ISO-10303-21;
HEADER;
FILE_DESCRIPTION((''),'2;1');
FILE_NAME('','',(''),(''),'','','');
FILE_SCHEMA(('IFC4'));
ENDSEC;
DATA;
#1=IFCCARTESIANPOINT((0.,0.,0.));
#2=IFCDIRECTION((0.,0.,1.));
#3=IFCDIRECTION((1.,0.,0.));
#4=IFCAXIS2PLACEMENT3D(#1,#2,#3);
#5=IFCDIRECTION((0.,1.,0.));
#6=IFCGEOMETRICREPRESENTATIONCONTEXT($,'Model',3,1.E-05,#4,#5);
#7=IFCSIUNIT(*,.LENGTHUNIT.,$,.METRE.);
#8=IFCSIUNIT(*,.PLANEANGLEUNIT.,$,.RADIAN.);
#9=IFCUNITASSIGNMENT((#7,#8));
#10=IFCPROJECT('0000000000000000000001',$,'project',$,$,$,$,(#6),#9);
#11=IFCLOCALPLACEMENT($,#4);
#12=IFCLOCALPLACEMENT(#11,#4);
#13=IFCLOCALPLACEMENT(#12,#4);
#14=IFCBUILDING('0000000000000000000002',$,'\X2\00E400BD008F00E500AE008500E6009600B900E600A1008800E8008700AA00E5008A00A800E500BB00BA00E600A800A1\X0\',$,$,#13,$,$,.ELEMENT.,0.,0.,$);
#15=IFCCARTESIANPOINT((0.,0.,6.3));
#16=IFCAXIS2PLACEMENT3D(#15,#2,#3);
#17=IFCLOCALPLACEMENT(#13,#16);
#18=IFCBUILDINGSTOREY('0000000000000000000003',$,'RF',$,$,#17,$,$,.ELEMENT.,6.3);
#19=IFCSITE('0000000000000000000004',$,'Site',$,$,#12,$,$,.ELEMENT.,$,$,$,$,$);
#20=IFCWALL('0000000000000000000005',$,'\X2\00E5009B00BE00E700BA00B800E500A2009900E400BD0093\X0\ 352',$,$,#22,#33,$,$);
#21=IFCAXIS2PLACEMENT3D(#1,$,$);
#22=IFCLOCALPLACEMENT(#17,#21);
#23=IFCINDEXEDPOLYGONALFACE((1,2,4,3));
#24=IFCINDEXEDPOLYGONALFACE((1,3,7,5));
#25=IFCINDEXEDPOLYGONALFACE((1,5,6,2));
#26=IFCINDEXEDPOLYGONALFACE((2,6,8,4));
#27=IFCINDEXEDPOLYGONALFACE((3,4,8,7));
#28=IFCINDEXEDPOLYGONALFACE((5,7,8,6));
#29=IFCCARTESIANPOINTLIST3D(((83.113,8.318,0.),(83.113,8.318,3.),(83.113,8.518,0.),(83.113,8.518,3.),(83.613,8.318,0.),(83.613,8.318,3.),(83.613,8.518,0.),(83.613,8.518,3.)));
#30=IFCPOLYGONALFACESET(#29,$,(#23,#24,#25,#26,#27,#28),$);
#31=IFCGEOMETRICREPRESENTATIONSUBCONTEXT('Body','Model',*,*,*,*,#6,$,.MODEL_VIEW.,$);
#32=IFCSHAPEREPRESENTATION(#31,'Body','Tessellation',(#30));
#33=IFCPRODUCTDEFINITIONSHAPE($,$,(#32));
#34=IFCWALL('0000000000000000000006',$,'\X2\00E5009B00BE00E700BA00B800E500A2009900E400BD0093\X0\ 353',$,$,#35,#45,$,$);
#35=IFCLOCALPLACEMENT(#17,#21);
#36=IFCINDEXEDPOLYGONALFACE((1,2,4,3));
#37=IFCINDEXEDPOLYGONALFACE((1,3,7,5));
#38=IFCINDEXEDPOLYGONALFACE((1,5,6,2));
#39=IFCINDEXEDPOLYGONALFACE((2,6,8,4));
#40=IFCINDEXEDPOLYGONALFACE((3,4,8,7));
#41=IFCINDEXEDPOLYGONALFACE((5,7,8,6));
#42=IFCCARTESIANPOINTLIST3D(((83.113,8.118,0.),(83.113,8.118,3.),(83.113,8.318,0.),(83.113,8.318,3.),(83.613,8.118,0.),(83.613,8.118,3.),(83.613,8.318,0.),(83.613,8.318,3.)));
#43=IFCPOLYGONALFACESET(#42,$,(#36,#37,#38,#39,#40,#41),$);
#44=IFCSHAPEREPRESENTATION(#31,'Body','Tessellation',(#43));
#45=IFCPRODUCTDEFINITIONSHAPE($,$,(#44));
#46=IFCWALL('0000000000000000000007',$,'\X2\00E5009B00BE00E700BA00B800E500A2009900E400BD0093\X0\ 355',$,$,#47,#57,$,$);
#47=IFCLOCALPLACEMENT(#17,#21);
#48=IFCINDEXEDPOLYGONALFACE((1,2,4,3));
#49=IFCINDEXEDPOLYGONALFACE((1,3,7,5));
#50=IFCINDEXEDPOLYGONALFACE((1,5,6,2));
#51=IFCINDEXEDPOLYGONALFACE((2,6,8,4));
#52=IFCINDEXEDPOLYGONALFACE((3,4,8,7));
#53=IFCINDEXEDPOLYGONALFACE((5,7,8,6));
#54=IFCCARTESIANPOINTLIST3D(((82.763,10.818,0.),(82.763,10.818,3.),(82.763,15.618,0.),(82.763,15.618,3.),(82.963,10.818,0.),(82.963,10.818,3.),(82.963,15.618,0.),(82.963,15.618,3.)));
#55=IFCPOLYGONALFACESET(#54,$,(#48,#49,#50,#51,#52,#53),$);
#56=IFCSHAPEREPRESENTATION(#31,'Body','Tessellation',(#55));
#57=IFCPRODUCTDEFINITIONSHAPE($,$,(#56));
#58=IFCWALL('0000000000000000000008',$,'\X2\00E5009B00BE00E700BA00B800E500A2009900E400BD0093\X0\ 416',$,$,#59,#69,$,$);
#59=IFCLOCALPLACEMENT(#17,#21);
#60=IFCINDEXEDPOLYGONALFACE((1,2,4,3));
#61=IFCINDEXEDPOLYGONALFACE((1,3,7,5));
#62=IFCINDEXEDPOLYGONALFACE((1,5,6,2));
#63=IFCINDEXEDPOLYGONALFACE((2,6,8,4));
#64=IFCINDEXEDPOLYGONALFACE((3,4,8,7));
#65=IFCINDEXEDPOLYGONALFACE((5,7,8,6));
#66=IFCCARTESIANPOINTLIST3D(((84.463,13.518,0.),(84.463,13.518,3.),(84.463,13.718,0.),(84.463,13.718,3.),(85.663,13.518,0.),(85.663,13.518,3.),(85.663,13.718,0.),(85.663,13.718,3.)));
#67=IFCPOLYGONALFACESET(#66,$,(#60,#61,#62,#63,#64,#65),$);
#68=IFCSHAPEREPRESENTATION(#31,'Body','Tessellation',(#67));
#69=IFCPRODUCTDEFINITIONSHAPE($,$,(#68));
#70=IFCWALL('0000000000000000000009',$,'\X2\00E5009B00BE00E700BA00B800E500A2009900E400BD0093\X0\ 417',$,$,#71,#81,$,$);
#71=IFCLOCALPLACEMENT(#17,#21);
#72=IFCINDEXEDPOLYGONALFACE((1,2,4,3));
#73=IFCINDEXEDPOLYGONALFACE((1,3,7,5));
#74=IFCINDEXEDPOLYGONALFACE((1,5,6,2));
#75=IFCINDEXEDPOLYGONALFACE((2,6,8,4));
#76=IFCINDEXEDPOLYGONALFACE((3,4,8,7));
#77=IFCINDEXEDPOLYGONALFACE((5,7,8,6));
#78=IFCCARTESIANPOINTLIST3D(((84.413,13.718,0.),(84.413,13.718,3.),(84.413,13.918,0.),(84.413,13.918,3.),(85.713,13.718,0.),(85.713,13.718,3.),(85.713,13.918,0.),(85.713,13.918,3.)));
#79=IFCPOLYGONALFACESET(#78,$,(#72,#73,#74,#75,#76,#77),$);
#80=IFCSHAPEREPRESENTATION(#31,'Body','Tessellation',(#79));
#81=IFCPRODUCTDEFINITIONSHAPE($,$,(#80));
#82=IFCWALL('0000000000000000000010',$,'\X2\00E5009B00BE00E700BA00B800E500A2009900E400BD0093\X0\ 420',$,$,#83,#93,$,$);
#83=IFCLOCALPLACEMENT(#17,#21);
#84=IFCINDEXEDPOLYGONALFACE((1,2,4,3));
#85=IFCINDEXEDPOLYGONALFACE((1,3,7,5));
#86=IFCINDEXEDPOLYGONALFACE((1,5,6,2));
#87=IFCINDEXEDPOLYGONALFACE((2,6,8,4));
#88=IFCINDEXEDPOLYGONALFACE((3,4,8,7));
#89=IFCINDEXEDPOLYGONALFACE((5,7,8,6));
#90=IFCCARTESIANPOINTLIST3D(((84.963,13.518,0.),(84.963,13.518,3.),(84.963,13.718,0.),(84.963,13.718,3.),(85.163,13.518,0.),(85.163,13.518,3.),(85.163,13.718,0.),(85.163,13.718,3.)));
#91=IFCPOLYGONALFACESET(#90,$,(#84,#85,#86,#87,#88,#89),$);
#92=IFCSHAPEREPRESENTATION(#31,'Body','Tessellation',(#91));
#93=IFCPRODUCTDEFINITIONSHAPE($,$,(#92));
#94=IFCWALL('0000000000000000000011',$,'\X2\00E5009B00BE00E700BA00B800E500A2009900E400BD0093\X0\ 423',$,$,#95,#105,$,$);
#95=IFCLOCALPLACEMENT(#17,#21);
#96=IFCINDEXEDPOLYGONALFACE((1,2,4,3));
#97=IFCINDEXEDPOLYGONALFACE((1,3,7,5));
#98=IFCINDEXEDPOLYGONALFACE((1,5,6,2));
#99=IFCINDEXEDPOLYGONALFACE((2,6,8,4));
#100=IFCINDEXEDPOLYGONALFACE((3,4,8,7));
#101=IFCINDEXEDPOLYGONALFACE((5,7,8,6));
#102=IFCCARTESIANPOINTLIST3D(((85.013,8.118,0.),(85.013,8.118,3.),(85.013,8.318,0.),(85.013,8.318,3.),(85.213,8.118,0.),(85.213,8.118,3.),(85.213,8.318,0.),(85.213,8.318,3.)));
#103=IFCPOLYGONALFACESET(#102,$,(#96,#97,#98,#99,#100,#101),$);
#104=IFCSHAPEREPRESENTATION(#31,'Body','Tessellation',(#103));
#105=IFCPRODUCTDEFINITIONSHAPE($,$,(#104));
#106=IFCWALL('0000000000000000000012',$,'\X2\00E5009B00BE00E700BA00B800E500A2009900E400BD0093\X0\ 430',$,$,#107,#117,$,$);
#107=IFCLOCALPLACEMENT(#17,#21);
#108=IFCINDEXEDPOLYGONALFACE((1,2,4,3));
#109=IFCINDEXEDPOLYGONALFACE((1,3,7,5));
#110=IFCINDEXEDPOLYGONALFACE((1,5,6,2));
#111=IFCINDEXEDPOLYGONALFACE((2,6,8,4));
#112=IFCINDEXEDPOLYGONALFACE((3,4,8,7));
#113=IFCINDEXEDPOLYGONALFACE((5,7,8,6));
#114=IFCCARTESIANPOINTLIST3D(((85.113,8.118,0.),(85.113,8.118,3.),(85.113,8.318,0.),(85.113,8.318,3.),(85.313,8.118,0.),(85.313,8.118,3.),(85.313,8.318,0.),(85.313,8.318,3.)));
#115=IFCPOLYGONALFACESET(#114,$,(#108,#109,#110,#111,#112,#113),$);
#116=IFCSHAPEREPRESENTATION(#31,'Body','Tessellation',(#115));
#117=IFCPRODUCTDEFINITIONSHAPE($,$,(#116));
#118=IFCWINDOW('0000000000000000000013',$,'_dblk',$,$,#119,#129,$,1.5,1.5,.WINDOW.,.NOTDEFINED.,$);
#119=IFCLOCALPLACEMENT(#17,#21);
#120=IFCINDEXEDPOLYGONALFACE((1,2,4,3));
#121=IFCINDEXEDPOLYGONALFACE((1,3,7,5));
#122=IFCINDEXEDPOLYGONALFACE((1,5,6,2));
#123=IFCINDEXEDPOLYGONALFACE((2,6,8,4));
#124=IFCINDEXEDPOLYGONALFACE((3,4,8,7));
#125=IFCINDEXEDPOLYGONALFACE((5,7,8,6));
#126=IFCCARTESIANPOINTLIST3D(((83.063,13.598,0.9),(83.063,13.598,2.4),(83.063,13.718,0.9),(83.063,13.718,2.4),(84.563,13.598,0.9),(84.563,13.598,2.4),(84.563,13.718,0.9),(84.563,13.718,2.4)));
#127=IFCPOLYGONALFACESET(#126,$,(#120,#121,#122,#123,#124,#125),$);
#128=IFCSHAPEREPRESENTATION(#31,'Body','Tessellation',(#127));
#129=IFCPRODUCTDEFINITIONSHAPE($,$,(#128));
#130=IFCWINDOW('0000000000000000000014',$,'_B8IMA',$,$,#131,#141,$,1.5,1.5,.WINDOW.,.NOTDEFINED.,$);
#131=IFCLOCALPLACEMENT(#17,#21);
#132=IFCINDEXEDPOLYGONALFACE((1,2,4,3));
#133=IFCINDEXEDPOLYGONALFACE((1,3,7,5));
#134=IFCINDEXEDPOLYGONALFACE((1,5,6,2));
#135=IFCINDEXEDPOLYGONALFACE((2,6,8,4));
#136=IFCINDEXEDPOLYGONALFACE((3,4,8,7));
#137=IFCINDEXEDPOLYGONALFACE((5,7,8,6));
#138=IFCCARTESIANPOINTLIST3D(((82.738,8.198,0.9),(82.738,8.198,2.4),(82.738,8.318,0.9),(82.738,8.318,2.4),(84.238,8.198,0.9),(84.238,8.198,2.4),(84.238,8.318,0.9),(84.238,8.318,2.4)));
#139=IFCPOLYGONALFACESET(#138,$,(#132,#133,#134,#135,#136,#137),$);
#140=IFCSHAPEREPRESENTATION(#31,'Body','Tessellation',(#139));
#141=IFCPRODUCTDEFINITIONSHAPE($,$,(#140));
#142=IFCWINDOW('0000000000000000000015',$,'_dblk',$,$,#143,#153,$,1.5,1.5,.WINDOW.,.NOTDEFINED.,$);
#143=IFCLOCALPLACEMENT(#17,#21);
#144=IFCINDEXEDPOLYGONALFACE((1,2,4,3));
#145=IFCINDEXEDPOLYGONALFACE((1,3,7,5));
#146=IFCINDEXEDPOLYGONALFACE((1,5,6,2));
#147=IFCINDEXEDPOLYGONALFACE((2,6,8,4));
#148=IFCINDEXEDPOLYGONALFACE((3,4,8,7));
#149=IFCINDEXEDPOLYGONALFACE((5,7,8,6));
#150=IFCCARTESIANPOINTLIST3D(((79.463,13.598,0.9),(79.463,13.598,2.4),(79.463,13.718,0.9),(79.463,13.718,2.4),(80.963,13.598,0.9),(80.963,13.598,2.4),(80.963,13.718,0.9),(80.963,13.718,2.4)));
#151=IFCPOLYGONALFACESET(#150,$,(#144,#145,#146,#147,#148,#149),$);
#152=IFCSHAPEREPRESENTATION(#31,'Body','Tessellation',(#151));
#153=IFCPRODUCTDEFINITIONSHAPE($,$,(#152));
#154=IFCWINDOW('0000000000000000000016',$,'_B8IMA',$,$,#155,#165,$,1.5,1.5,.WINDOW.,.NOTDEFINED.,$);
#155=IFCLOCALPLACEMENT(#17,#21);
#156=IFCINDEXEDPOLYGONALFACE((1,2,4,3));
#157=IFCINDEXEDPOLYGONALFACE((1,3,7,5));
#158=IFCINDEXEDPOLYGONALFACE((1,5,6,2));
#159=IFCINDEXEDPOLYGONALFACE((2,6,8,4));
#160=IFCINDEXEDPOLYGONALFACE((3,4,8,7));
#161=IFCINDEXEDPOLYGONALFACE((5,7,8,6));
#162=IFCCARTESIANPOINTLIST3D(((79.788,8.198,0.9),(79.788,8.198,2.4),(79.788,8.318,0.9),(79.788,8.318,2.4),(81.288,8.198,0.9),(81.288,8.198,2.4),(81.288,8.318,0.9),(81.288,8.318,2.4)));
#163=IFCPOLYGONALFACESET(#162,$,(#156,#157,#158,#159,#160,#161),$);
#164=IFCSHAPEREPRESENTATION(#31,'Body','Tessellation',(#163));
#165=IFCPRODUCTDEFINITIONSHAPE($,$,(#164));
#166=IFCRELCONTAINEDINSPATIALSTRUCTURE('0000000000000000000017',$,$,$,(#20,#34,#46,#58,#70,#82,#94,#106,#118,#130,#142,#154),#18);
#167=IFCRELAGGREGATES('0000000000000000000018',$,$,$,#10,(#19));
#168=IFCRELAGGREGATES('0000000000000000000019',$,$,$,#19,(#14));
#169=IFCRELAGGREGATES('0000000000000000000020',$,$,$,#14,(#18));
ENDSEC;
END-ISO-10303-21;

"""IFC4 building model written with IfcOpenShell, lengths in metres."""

from ifc_helpers import new_model, si_unit, direction, frame, frame_2d, origin_with_axes, place, context, subcontext, project, spatial, rectangle, extrude, element, save


model = new_model("IFC4")

# Units and contexts
model_context = context("Model", 3, precision=1e-05, world=origin_with_axes(), true_north=direction((0.0, 1.0, 0.0)))
body_context = subcontext(model_context, "Body", "Model", "MODEL_VIEW")
ifc_project = project(units=[si_unit("LENGTHUNIT", "METRE"), si_unit("PLANEANGLEUNIT", "RADIAN")], contexts=[model_context])

# Site, building, storey
placement = place(None, origin_with_axes())
site_placement = place(placement, origin_with_axes())
site = spatial("IfcSite", under=ifc_project, at=site_placement, Name="Site", CompositionType="ELEMENT")
building_placement = place(site_placement, origin_with_axes())
building = spatial("IfcBuilding", under=site, at=building_placement, Name="ä½\u008få®\u0085æ\u0096¹æ¡\u0088è\u0087ªå\u008a¨å»ºæ¨¡", CompositionType="ELEMENT", ElevationOfRefHeight=0.0, ElevationOfTerrain=0.0)
storey_placement = place(building_placement, frame((0.0, 0.0, 6.3), z_axis=(0.0, 0.0, 1.0), x_axis=(1.0, 0.0, 0.0)))
storey = spatial("IfcBuildingStorey", under=building, at=storey_placement, Name="RF", CompositionType="ELEMENT", Elevation=6.3)

# Walls
for number, where, z_axis, x_axis, name in (
    (1, (83.363, 8.418, 0.0), (0.0, 0.0, 1.0), (-1.0, 0.0, 0.0), "å\u009b¾çº¸å¢\u0099ä½\u0093 352"),
    (2, (83.363, 8.218, 0.0), (0.0, 0.0, 1.0), (-1.0, 0.0, 0.0), "å\u009b¾çº¸å¢\u0099ä½\u0093 353"),
):
    element("IfcWall", number, at=place(storey_placement, frame(where, z_axis=z_axis, x_axis=x_axis)), inside=storey, Name=name, context=body_context, shape_type="SweptSolid", body=[
        extrude(rectangle(XDim=0.5, YDim=0.2, at=frame_2d((0.0, 0.0), x_axis=(1.0, 0.0, 0.0))), frame((0.0, 0.0, 0.0), z_axis=(0.0, 0.0, 1.0)), (0.0, 0.0, 1.0), 3.0),
    ])
wall_1_placement = place(storey_placement, frame((82.863, 13.218, 0.0), z_axis=(0.0, 0.0, 1.0), x_axis=(0.0, -1.0, 0.0)))
element("IfcWall", 3, at=wall_1_placement, inside=storey, Name="å\u009b¾çº¸å¢\u0099ä½\u0093 355", context=body_context, shape_type="SweptSolid", body=[
    extrude(rectangle(XDim=4.8, YDim=0.2, at=frame_2d((0.0, 0.0), x_axis=(1.0, 0.0, 0.0))), frame((0.0, 0.0, 0.0), z_axis=(0.0, 0.0, 1.0)), (0.0, 0.0, 1.0), 3.0),
])
wall_2_placement = place(storey_placement, frame((85.063, 13.618, 0.0), z_axis=(0.0, 0.0, 1.0), x_axis=(1.0, 0.0, 0.0)))
element("IfcWall", 4, at=wall_2_placement, inside=storey, Name="å\u009b¾çº¸å¢\u0099ä½\u0093 416", context=body_context, shape_type="SweptSolid", body=[
    extrude(rectangle(XDim=1.2, YDim=0.2, at=frame_2d((0.0, 0.0), x_axis=(1.0, 0.0, 0.0))), frame((0.0, 0.0, 0.0), z_axis=(0.0, 0.0, 1.0)), (0.0, 0.0, 1.0), 3.0),
])
wall_3_placement = place(storey_placement, frame((85.063, 13.818, 0.0), z_axis=(0.0, 0.0, 1.0), x_axis=(1.0, 0.0, 0.0)))
element("IfcWall", 5, at=wall_3_placement, inside=storey, Name="å\u009b¾çº¸å¢\u0099ä½\u0093 417", context=body_context, shape_type="SweptSolid", body=[
    extrude(rectangle(XDim=1.3, YDim=0.2, at=frame_2d((0.0, 0.0), x_axis=(1.0, 0.0, 0.0))), frame((0.0, 0.0, 0.0), z_axis=(0.0, 0.0, 1.0)), (0.0, 0.0, 1.0), 3.0),
])
for number, where, z_axis, x_axis, name in (
    (6, (85.063, 13.618, 0.0), (0.0, 0.0, 1.0), (0.0, 1.0, 0.0), "å\u009b¾çº¸å¢\u0099ä½\u0093 420"),
    (7, (85.113, 8.218, 0.0), (0.0, 0.0, 1.0), (0.0, 1.0, 0.0), "å\u009b¾çº¸å¢\u0099ä½\u0093 423"),
    (8, (85.213, 8.218, 0.0), (0.0, 0.0, 1.0), (0.0, -1.0, 0.0), "å\u009b¾çº¸å¢\u0099ä½\u0093 430"),
):
    element("IfcWall", number, at=place(storey_placement, frame(where, z_axis=z_axis, x_axis=x_axis)), inside=storey, Name=name, context=body_context, shape_type="SweptSolid", body=[
        extrude(rectangle(XDim=0.2, YDim=0.2, at=frame_2d((0.0, 0.0), x_axis=(1.0, 0.0, 0.0))), frame((0.0, 0.0, 0.0), z_axis=(0.0, 0.0, 1.0)), (0.0, 0.0, 1.0), 3.0),
    ])

# Windows
for number, where, z_axis, x_axis, name in (
    (9, (83.813, 13.658, 0.9), (0.0, 0.0, 1.0), (1.0, 0.0, 0.0), "_dblk"),
    (10, (83.488, 8.258, 0.9), (0.0, 0.0, 1.0), (1.0, 0.0, 0.0), "_B8IMA"),
    (11, (80.213, 13.658, 0.9), (0.0, 0.0, 1.0), (1.0, 0.0, 0.0), "_dblk"),
    (12, (80.538, 8.258, 0.9), (0.0, 0.0, 1.0), (1.0, 0.0, 0.0), "_B8IMA"),
):
    element("IfcWindow", number, at=place(storey_placement, frame(where, z_axis=z_axis, x_axis=x_axis)), inside=storey, Name=name, OverallHeight=1.5, OverallWidth=1.5, PartitioningType="NOTDEFINED", PredefinedType="WINDOW", context=body_context, shape_type="SweptSolid", body=[
        extrude(rectangle(XDim=1.5, YDim=0.12, at=frame_2d((0.0, 0.0), x_axis=(1.0, 0.0, 0.0))), frame((0.0, 0.0, 0.0), z_axis=(0.0, 0.0, 1.0)), (0.0, 0.0, 1.0), 1.5),
    ])

save(model, "model.ifc")
